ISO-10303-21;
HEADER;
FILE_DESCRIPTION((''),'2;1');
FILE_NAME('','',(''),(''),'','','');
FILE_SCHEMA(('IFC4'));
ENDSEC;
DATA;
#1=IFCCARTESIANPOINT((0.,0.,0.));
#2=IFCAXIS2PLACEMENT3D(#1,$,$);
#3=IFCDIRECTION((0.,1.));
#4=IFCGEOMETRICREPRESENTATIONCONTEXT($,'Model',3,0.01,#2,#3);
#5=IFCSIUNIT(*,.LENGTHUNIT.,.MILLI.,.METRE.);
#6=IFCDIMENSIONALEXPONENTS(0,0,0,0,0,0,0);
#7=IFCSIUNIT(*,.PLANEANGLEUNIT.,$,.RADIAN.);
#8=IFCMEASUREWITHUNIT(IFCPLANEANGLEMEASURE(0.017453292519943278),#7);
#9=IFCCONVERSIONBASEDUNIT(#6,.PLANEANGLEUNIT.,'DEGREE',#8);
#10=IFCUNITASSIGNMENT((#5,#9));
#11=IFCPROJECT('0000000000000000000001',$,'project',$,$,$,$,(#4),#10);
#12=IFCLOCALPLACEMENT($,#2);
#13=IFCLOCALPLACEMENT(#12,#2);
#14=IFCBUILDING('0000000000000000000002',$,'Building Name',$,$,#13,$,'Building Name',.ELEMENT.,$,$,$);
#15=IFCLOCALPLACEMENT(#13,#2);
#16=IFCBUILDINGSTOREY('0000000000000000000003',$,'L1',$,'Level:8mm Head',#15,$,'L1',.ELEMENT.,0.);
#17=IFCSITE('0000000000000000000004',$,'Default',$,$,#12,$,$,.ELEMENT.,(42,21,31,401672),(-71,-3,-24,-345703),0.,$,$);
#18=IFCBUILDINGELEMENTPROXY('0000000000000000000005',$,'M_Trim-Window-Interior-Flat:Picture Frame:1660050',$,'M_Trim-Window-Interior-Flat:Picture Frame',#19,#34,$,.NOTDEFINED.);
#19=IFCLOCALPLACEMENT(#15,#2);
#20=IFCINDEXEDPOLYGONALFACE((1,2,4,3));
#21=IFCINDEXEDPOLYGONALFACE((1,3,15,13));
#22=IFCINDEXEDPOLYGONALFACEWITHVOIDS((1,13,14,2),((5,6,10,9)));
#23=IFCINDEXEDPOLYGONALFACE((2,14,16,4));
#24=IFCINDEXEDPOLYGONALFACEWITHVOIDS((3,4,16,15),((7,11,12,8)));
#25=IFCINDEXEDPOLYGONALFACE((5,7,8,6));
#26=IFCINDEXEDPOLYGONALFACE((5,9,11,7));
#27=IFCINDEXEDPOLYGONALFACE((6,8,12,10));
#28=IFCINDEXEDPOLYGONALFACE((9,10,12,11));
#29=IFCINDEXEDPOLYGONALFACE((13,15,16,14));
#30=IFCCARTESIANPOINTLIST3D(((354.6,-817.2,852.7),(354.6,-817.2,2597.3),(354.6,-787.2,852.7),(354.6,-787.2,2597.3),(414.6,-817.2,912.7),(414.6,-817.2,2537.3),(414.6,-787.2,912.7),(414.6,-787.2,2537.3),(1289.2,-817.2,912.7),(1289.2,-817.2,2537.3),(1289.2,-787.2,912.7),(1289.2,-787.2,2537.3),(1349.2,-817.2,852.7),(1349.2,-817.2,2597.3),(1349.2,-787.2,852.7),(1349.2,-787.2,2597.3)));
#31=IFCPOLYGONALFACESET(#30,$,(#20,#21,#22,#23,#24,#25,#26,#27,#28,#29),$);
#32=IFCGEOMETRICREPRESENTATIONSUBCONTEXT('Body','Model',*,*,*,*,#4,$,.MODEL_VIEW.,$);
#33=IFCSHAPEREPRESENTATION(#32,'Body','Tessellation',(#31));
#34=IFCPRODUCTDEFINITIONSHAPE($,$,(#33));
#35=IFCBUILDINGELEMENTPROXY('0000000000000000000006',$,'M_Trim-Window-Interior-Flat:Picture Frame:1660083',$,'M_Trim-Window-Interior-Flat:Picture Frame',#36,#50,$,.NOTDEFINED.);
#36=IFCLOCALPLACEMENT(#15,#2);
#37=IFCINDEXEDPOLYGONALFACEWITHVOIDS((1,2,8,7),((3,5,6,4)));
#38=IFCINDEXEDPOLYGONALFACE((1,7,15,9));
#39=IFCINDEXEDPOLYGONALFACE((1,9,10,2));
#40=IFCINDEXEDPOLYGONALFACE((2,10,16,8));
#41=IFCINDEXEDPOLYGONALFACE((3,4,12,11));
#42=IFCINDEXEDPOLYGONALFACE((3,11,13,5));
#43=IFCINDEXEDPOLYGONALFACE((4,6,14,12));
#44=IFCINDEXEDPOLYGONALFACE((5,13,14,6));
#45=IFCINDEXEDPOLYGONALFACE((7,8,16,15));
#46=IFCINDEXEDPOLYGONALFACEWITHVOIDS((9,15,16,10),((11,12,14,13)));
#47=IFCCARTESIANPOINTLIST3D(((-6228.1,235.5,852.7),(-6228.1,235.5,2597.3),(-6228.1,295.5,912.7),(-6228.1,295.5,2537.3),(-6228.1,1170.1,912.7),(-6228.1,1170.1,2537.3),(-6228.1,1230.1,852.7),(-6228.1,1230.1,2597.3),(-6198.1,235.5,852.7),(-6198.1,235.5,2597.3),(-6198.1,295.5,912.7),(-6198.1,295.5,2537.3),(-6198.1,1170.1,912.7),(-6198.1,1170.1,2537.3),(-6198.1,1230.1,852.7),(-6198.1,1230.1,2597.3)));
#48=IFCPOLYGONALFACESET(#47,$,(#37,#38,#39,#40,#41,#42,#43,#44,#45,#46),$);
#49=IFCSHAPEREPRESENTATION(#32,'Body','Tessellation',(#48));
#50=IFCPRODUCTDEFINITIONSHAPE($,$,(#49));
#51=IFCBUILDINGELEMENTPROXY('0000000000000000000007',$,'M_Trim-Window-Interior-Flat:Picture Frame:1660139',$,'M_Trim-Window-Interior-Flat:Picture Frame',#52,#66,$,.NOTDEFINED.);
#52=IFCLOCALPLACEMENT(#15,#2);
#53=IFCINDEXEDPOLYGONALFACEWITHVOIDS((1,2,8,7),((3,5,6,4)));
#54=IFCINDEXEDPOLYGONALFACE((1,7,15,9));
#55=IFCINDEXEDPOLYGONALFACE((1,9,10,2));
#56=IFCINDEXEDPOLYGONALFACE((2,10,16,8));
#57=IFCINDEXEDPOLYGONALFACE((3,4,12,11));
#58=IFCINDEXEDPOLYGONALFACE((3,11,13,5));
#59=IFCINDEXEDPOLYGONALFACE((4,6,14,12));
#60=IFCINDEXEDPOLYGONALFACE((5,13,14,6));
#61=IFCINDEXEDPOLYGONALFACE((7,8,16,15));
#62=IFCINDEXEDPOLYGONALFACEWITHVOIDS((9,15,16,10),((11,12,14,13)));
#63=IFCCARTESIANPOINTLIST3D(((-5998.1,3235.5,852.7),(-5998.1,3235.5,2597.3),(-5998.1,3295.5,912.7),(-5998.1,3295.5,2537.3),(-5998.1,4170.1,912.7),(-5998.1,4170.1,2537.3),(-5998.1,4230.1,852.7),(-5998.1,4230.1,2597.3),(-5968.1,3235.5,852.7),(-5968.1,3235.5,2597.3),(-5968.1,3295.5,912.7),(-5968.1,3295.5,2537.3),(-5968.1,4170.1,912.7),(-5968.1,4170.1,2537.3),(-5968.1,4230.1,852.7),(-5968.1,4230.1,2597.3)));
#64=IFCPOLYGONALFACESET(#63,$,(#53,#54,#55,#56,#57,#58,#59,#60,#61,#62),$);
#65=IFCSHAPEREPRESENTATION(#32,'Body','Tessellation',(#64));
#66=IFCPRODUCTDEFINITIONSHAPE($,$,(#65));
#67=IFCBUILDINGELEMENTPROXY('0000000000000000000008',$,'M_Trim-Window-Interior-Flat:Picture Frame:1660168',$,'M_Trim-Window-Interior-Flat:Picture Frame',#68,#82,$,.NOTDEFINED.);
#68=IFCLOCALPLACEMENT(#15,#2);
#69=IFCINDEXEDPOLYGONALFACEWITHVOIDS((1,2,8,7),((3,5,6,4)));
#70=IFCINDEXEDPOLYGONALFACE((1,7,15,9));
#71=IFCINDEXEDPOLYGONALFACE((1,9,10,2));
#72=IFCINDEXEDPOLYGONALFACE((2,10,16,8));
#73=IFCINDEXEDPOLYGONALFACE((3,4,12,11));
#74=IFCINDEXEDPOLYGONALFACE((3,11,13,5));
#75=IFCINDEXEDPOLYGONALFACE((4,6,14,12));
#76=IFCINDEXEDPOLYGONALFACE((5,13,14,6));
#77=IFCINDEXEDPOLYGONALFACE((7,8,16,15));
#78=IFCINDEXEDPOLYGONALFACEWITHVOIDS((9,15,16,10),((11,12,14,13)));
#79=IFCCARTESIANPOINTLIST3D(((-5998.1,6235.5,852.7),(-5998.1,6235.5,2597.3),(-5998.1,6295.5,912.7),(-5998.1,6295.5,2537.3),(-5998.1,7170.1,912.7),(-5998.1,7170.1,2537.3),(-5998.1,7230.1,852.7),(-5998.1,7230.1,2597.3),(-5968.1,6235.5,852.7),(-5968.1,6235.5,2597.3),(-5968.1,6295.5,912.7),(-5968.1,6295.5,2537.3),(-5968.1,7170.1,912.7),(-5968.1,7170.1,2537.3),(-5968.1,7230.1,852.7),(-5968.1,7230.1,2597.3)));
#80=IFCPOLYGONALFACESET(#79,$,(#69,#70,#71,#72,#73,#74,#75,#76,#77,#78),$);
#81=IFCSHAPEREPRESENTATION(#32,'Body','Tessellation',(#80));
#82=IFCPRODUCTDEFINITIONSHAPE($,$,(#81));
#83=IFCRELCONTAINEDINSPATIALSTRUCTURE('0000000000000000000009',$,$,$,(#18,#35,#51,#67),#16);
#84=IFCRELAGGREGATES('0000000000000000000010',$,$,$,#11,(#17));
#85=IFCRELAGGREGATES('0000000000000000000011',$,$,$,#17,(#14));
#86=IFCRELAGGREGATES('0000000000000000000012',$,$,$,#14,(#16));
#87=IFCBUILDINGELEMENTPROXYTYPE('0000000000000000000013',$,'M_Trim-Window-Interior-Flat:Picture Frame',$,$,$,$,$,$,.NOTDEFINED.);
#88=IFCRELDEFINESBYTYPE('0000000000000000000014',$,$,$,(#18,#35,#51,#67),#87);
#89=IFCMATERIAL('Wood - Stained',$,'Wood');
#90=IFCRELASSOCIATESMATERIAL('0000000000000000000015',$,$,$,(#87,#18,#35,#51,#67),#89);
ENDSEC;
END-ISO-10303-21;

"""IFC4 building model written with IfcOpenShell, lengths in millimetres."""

from ifc_helpers import new_model, entity, si_unit, converted_unit, direction, frame, origin, place, context, subcontext, project, spatial, indexed_curve, outline, extrude, source, transform, mapped, material, type_object, type_shapes, element, save


model = new_model("IFC4")

# Units and contexts
model_context = context("Model", 3, precision=0.01, world=origin(), true_north=direction((0.0, 1.0)))
body_context = subcontext(model_context, "Body", "Model", "MODEL_VIEW")
ifc_project = project(units=[si_unit("LENGTHUNIT", "METRE", prefix="MILLI"), converted_unit("PLANEANGLEUNIT", "DEGREE", entity("IfcPlaneAngleMeasure", 0.017453292519943278), si_unit("PLANEANGLEUNIT", "RADIAN"), dimensions=[0, 0, 0, 0, 0, 0, 0])], contexts=[model_context])

# Site, building, storey
site_placement = place(None, origin())
site = spatial("IfcSite", under=ifc_project, at=site_placement, Name="Default", CompositionType="ELEMENT", RefLatitude=(42, 21, 31, 401672), RefLongitude=(-71, -3, -24, -345703), RefElevation=0.0)
building_placement = place(site_placement, origin())
building = spatial("IfcBuilding", under=site, at=building_placement, Name="Building Name", LongName="Building Name", CompositionType="ELEMENT")
storey_placement = place(building_placement, origin())
storey = spatial("IfcBuildingStorey", under=building, at=storey_placement, Name="L1", ObjectType="Level:8mm Head", LongName="L1", CompositionType="ELEMENT", Elevation=0.0)

# Building element proxies
ifc_material_1 = material(Name="Wood - Stained", Category="Wood")
building_element_proxy_type_1 = type_object("IfcBuildingElementProxyType", Name="M_Trim-Window-Interior-Flat:Picture Frame", PredefinedType="NOTDEFINED", material=ifc_material_1)
shared_shape_1 = source(origin(), body_context, "Body", "SweptSolid", [
    extrude(outline(indexed_curve([(-497.3, -872.3), (497.3, -872.3), (497.3, 872.3), (-497.3, 872.3), (-497.3, -872.3)], self_intersect=False), holes=[indexed_curve([(-437.3, -812.3), (-437.3, 812.3), (437.3, 812.3), (437.3, -812.3), (-437.3, -812.3)], self_intersect=False)]), frame((0.0, -825.0, 0.0), z_axis=(0.0, 0.0, 1.0), x_axis=(-1.0, 0.0, 0.0)), (0.0, 0.0, 1.0), 30.0),
])
type_shapes(building_element_proxy_type_1, [shared_shape_1])
for number, where, z_axis, x_axis, name in (
    (1, (851.9, -817.2, 2550.0), (0.0, 1.0, 0.0), (-1.0, 0.0, 0.0), "M_Trim-Window-Interior-Flat:Picture Frame:1660050"),
    (2, (-6198.1, 732.8, 2550.0), (-1.0, 0.0, 0.0), (0.0, -1.0, 0.0), "M_Trim-Window-Interior-Flat:Picture Frame:1660083"),
    (3, (-5998.1, 3732.8, 2550.0), (1.0, 0.0, 0.0), (0.0, 1.0, 0.0), "M_Trim-Window-Interior-Flat:Picture Frame:1660139"),
    (4, (-5998.1, 6732.8, 2550.0), (1.0, 0.0, 0.0), (0.0, 1.0, 0.0), "M_Trim-Window-Interior-Flat:Picture Frame:1660168"),
):
    element("IfcBuildingElementProxy", number, at=place(storey_placement, frame(where, z_axis=z_axis, x_axis=x_axis)), inside=storey, type_object=building_element_proxy_type_1, material=ifc_material_1, Name=name, ObjectType="M_Trim-Window-Interior-Flat:Picture Frame", PredefinedType="NOTDEFINED", context=body_context, shape_type="MappedRepresentation", body=[
        mapped(shared_shape_1, transform((0.0, 0.0, 0.0), scale=1.0)),
    ])

save(model, "model.ifc")
